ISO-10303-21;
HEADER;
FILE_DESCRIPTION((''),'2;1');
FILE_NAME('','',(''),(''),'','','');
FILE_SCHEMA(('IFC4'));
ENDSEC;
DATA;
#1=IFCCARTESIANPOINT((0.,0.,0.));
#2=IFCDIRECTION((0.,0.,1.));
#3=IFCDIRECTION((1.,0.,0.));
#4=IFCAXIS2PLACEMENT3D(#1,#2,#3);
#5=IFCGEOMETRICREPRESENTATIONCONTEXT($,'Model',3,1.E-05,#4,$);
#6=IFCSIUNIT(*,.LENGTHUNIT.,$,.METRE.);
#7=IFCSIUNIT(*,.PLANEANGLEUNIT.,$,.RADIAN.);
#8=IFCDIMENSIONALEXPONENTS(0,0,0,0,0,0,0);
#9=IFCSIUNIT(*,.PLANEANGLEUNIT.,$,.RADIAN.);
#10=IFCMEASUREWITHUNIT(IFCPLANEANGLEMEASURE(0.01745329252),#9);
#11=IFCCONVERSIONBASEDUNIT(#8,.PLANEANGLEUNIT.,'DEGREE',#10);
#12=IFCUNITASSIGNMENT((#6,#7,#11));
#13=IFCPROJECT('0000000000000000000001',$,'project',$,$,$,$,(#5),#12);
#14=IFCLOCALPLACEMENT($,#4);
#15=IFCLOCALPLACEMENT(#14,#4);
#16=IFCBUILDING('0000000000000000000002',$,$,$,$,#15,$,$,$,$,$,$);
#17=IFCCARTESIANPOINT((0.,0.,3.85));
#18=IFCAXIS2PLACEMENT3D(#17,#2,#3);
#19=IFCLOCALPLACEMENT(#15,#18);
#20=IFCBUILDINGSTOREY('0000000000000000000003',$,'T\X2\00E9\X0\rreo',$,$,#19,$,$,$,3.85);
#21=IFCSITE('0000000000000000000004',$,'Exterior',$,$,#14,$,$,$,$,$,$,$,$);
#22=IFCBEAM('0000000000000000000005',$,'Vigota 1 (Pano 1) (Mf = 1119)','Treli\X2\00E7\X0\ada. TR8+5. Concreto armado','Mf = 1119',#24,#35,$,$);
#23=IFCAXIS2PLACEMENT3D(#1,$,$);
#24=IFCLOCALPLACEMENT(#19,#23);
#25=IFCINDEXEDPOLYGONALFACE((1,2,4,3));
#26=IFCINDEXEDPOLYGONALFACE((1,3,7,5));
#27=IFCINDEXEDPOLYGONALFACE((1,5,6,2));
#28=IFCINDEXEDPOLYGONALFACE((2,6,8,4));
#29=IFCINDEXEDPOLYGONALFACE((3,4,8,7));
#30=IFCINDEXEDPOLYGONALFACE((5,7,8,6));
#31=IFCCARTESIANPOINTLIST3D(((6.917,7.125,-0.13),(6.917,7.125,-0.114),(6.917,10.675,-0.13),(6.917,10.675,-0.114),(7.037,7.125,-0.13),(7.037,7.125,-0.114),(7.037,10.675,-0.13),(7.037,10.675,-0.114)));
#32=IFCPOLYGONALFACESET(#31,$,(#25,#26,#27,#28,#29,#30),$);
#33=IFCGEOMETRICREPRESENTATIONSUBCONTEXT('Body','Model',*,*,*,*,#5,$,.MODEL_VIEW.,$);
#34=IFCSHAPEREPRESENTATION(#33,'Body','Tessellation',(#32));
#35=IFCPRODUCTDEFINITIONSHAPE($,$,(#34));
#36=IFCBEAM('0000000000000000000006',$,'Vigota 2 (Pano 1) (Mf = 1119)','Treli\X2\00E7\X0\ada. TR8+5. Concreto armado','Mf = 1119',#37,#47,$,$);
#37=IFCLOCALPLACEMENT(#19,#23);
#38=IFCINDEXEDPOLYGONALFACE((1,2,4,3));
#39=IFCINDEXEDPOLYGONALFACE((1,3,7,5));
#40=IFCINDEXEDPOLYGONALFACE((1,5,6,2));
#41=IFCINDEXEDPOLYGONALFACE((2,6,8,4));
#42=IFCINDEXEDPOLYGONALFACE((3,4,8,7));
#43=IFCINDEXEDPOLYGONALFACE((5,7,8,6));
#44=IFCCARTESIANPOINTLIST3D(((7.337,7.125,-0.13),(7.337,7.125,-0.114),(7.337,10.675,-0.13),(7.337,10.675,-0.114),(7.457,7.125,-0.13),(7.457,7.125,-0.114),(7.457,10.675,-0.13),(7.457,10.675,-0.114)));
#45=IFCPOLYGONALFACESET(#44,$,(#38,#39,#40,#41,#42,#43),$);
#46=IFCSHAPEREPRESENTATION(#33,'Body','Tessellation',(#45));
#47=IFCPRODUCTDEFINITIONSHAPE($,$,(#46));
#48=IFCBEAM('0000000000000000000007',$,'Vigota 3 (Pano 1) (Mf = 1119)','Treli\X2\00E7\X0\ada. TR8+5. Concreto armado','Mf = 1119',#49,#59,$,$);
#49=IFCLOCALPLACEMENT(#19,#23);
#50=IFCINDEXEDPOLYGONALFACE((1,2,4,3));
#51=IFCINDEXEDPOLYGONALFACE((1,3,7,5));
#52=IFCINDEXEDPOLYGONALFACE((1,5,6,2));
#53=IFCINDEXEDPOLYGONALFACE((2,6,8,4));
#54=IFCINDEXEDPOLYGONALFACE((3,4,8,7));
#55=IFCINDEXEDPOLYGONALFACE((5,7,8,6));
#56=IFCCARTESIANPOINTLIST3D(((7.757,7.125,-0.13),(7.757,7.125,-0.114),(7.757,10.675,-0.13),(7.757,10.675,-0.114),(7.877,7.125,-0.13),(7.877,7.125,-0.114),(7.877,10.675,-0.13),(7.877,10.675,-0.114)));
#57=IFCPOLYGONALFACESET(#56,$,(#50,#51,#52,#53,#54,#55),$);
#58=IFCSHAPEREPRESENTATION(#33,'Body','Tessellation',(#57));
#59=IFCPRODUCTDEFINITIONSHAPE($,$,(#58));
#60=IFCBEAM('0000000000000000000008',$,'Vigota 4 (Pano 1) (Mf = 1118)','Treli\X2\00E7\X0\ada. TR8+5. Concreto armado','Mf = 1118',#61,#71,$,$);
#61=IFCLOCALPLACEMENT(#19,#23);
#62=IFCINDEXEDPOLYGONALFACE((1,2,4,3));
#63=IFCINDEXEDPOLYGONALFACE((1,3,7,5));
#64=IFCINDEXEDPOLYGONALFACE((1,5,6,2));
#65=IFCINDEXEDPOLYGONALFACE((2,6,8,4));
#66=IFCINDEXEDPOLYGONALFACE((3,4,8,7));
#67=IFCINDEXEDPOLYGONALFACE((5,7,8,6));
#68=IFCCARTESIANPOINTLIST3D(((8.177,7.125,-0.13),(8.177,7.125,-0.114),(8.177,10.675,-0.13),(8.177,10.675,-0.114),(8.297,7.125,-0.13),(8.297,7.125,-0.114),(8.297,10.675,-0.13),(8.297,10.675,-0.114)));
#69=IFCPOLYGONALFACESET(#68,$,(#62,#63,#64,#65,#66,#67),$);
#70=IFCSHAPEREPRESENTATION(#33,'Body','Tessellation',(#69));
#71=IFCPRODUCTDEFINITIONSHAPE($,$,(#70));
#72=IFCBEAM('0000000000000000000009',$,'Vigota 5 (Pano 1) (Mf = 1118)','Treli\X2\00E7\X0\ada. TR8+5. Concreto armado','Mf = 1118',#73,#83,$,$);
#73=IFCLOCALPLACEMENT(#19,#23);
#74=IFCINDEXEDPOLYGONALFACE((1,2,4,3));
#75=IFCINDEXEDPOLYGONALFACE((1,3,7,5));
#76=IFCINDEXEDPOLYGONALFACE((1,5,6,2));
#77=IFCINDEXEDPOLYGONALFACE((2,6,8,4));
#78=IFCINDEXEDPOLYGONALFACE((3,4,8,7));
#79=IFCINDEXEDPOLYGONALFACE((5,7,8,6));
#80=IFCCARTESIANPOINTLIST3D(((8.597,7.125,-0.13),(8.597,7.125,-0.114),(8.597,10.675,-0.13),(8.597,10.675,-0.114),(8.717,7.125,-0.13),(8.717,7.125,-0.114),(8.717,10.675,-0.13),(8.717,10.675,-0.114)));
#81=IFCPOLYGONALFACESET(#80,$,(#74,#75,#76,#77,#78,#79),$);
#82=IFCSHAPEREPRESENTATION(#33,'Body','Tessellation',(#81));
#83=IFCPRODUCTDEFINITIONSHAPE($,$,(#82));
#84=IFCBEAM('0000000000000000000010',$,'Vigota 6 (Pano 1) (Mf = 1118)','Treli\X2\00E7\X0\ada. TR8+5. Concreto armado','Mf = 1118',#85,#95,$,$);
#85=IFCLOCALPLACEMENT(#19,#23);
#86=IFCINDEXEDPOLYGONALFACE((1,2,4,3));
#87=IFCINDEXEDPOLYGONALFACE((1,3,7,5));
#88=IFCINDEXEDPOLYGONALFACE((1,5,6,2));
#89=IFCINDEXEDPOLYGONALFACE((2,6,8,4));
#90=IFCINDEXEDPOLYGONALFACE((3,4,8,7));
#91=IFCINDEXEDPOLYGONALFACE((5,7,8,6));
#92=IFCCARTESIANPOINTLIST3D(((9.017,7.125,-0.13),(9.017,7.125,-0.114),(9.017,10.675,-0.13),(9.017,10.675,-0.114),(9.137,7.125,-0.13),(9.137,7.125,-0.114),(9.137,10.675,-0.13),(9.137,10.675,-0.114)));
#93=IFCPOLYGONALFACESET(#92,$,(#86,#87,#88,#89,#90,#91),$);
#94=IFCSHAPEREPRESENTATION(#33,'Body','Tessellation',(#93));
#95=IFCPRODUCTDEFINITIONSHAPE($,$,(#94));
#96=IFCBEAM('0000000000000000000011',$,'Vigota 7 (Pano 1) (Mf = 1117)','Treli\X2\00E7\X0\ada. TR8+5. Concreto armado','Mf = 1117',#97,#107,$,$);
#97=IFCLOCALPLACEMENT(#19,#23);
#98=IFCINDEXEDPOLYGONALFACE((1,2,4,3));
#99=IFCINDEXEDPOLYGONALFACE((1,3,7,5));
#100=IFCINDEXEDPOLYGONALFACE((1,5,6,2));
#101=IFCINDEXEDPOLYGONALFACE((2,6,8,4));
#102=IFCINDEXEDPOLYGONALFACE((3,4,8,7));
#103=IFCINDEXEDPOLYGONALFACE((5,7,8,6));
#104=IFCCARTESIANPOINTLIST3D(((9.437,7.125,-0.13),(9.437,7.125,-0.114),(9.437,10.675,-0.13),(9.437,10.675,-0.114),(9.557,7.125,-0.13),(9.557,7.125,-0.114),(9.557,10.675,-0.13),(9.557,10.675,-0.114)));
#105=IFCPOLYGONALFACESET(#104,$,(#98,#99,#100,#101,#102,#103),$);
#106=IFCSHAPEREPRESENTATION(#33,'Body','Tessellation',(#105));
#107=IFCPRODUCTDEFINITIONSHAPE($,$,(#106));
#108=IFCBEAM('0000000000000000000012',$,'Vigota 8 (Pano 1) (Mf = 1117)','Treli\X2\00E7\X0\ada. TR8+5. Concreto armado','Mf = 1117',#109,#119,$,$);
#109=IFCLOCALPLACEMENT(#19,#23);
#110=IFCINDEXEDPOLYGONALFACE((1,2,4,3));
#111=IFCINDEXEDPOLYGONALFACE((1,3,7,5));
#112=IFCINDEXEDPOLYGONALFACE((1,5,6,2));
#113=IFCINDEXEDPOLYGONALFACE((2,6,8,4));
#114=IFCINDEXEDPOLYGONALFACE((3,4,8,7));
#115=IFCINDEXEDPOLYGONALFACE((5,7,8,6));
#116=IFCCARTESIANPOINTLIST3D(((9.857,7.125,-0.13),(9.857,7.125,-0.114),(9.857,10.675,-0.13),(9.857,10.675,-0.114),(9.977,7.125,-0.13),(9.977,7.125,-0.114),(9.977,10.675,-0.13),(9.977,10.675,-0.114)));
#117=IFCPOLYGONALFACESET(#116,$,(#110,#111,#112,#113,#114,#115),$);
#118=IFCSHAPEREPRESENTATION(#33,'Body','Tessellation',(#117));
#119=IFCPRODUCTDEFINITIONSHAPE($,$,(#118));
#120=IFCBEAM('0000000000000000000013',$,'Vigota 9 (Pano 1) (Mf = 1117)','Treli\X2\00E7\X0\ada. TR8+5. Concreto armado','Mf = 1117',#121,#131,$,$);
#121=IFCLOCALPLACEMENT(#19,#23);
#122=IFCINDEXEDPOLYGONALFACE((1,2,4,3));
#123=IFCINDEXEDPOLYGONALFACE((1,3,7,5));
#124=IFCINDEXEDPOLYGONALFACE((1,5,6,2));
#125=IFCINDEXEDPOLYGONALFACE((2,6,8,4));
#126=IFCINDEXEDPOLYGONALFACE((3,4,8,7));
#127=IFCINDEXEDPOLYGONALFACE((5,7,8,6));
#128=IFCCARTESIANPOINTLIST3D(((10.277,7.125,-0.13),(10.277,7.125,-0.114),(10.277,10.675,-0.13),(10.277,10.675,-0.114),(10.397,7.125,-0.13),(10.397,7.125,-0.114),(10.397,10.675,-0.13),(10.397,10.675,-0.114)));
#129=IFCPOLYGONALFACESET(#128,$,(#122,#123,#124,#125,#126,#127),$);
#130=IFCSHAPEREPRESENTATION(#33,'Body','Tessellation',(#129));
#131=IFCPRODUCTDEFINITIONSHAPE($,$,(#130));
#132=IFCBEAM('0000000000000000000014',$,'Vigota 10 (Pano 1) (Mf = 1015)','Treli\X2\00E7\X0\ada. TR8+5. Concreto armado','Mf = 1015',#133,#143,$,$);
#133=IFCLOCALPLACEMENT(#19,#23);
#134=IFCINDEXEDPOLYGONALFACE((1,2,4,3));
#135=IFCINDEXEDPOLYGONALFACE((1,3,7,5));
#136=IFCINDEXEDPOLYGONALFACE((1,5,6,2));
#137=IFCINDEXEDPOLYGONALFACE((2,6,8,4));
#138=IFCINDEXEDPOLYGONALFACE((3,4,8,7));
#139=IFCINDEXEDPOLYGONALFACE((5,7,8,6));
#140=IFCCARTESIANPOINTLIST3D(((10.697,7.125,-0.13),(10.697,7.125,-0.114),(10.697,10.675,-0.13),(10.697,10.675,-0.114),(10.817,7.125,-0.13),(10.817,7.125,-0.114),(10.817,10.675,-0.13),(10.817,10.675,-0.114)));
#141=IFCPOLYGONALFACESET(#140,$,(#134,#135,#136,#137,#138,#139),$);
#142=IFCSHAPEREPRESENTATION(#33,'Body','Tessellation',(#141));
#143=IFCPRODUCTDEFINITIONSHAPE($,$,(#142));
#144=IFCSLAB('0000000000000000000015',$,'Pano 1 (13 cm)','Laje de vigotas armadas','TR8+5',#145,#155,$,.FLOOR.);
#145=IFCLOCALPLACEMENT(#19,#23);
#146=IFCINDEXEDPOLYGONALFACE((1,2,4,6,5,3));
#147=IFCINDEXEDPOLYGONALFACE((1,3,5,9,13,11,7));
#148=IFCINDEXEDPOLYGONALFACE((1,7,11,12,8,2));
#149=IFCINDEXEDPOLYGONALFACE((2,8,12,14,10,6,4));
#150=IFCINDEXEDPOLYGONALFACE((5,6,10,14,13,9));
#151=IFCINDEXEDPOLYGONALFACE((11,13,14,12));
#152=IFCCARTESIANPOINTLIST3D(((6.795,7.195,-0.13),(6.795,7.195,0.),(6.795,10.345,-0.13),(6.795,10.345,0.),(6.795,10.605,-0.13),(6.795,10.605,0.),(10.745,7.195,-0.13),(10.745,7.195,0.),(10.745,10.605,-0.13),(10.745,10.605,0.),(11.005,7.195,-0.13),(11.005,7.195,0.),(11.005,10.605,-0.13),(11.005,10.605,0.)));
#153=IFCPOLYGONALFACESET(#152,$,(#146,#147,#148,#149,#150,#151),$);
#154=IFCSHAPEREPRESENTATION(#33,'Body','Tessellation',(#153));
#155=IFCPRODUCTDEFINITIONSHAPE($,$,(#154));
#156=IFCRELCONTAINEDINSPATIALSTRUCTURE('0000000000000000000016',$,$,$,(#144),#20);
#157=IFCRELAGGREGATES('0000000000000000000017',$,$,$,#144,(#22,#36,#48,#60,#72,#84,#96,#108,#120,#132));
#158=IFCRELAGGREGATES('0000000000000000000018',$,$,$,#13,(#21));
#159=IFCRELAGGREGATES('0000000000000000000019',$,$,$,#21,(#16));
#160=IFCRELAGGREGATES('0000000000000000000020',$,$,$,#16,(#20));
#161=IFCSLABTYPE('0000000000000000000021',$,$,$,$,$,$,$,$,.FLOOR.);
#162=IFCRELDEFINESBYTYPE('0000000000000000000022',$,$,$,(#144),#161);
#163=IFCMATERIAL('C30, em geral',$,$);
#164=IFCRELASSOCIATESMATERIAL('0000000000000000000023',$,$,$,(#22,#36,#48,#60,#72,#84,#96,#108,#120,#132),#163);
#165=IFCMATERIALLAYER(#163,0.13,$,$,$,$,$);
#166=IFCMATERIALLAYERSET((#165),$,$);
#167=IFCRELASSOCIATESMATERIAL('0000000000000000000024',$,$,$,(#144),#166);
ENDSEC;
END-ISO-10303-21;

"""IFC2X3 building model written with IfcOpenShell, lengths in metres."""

from ifc_helpers import new_model, entity, si_unit, converted_unit, frame, origin_with_axes, place, context, subcontext, project, spatial, polyline, outline, extrude, material, layer, layer_set, layer_usage, type_object, element, aggregate, save


model = new_model("IFC2X3")

# Units and contexts
model_context = context("Model", 3, precision=1e-05, world=origin_with_axes())
body_context = subcontext(model_context, "Body", "Model", "MODEL_VIEW")
ifc_project = project(units=[si_unit("LENGTHUNIT", "METRE"), si_unit("PLANEANGLEUNIT", "RADIAN"), converted_unit("PLANEANGLEUNIT", "DEGREE", entity("IfcPlaneAngleMeasure", 0.01745329252), si_unit("PLANEANGLEUNIT", "RADIAN"), dimensions=[0, 0, 0, 0, 0, 0, 0])], contexts=[model_context])

# Beams
ifc_material = material(Name="C30, em geral")
site_placement = place(None, origin_with_axes())
building_placement = place(site_placement, origin_with_axes())
storey_placement = place(building_placement, frame((0.0, 0.0, 3.85), z_axis=(0.0, 0.0, 1.0), x_axis=(1.0, 0.0, 0.0)))
beam_1_placement = place(storey_placement, frame((6.977, 7.125, -0.122), z_axis=(0.0, 1.0, 0.0), x_axis=(-1.0, 0.0, 0.0)))
beam_1 = element("IfcBeam", 1, at=beam_1_placement, material=ifc_material, Name="Vigota 1 (Pano 1) (Mf = 1119)", Description="Treliçada. TR8+5. Concreto armado", ObjectType="Mf = 1119", context=body_context, shape_type="SweptSolid", body=[
    extrude(outline(polyline([(0.06, 0.008), (-0.06, 0.008), (-0.06, -0.008), (0.06, -0.008), (0.06, 0.008)])), origin_with_axes(), (0.0, 0.0, 1.0), 3.55),
])
beam_2_placement = place(storey_placement, frame((7.397, 7.125, -0.122), z_axis=(0.0, 1.0, 0.0), x_axis=(-1.0, 0.0, 0.0)))
beam_2 = element("IfcBeam", 2, at=beam_2_placement, material=ifc_material, Name="Vigota 2 (Pano 1) (Mf = 1119)", Description="Treliçada. TR8+5. Concreto armado", ObjectType="Mf = 1119", context=body_context, shape_type="SweptSolid", body=[
    extrude(outline(polyline([(0.06, 0.008), (-0.06, 0.008), (-0.06, -0.008), (0.06, -0.008), (0.06, 0.008)])), origin_with_axes(), (0.0, 0.0, 1.0), 3.55),
])
beam_3_placement = place(storey_placement, frame((7.817, 7.125, -0.122), z_axis=(0.0, 1.0, 0.0), x_axis=(-1.0, 0.0, 0.0)))
beam_3 = element("IfcBeam", 3, at=beam_3_placement, material=ifc_material, Name="Vigota 3 (Pano 1) (Mf = 1119)", Description="Treliçada. TR8+5. Concreto armado", ObjectType="Mf = 1119", context=body_context, shape_type="SweptSolid", body=[
    extrude(outline(polyline([(0.06, 0.008), (-0.06, 0.008), (-0.06, -0.008), (0.06, -0.008), (0.06, 0.008)])), origin_with_axes(), (0.0, 0.0, 1.0), 3.55),
])
beam_4_placement = place(storey_placement, frame((8.237, 7.125, -0.122), z_axis=(0.0, 1.0, 0.0), x_axis=(-1.0, 0.0, 0.0)))
beam_4 = element("IfcBeam", 4, at=beam_4_placement, material=ifc_material, Name="Vigota 4 (Pano 1) (Mf = 1118)", Description="Treliçada. TR8+5. Concreto armado", ObjectType="Mf = 1118", context=body_context, shape_type="SweptSolid", body=[
    extrude(outline(polyline([(0.06, 0.008), (-0.06, 0.008), (-0.06, -0.008), (0.06, -0.008), (0.06, 0.008)])), origin_with_axes(), (0.0, 0.0, 1.0), 3.55),
])
beam_5_placement = place(storey_placement, frame((8.657, 7.125, -0.122), z_axis=(0.0, 1.0, 0.0), x_axis=(-1.0, 0.0, 0.0)))
beam_5 = element("IfcBeam", 5, at=beam_5_placement, material=ifc_material, Name="Vigota 5 (Pano 1) (Mf = 1118)", Description="Treliçada. TR8+5. Concreto armado", ObjectType="Mf = 1118", context=body_context, shape_type="SweptSolid", body=[
    extrude(outline(polyline([(0.06, 0.008), (-0.06, 0.008), (-0.06, -0.008), (0.06, -0.008), (0.06, 0.008)])), origin_with_axes(), (0.0, 0.0, 1.0), 3.55),
])
beam_6_placement = place(storey_placement, frame((9.077, 7.125, -0.122), z_axis=(0.0, 1.0, 0.0), x_axis=(-1.0, 0.0, 0.0)))
beam_6 = element("IfcBeam", 6, at=beam_6_placement, material=ifc_material, Name="Vigota 6 (Pano 1) (Mf = 1118)", Description="Treliçada. TR8+5. Concreto armado", ObjectType="Mf = 1118", context=body_context, shape_type="SweptSolid", body=[
    extrude(outline(polyline([(0.06, 0.008), (-0.06, 0.008), (-0.06, -0.008), (0.06, -0.008), (0.06, 0.008)])), origin_with_axes(), (0.0, 0.0, 1.0), 3.55),
])
beam_7_placement = place(storey_placement, frame((9.497, 7.125, -0.122), z_axis=(0.0, 1.0, 0.0), x_axis=(-1.0, 0.0, 0.0)))
beam_7 = element("IfcBeam", 7, at=beam_7_placement, material=ifc_material, Name="Vigota 7 (Pano 1) (Mf = 1117)", Description="Treliçada. TR8+5. Concreto armado", ObjectType="Mf = 1117", context=body_context, shape_type="SweptSolid", body=[
    extrude(outline(polyline([(0.06, 0.008), (-0.06, 0.008), (-0.06, -0.008), (0.06, -0.008), (0.06, 0.008)])), origin_with_axes(), (0.0, 0.0, 1.0), 3.55),
])
beam_8_placement = place(storey_placement, frame((9.917, 7.125, -0.122), z_axis=(0.0, 1.0, 0.0), x_axis=(-1.0, 0.0, 0.0)))
beam_8 = element("IfcBeam", 8, at=beam_8_placement, material=ifc_material, Name="Vigota 8 (Pano 1) (Mf = 1117)", Description="Treliçada. TR8+5. Concreto armado", ObjectType="Mf = 1117", context=body_context, shape_type="SweptSolid", body=[
    extrude(outline(polyline([(0.06, 0.008), (-0.06, 0.008), (-0.06, -0.008), (0.06, -0.008), (0.06, 0.008)])), origin_with_axes(), (0.0, 0.0, 1.0), 3.55),
])
beam_9_placement = place(storey_placement, frame((10.337, 7.125, -0.122), z_axis=(0.0, 1.0, 0.0), x_axis=(-1.0, 0.0, 0.0)))
beam_9 = element("IfcBeam", 9, at=beam_9_placement, material=ifc_material, Name="Vigota 9 (Pano 1) (Mf = 1117)", Description="Treliçada. TR8+5. Concreto armado", ObjectType="Mf = 1117", context=body_context, shape_type="SweptSolid", body=[
    extrude(outline(polyline([(0.06, 0.008), (-0.06, 0.008), (-0.06, -0.008), (0.06, -0.008), (0.06, 0.008)])), origin_with_axes(), (0.0, 0.0, 1.0), 3.55),
])
beam_10_placement = place(storey_placement, frame((10.757, 7.125, -0.122), z_axis=(0.0, 1.0, 0.0), x_axis=(-1.0, 0.0, 0.0)))
beam_10 = element("IfcBeam", 10, at=beam_10_placement, material=ifc_material, Name="Vigota 10 (Pano 1) (Mf = 1015)", Description="Treliçada. TR8+5. Concreto armado", ObjectType="Mf = 1015", context=body_context, shape_type="SweptSolid", body=[
    extrude(outline(polyline([(0.06, 0.008), (-0.06, 0.008), (-0.06, -0.008), (0.06, -0.008), (0.06, 0.008)])), origin_with_axes(), (0.0, 0.0, 1.0), 3.55),
])

# Site, building, storey
site = spatial("IfcSite", under=ifc_project, at=site_placement, Name="Exterior")
building = spatial("IfcBuilding", under=site, at=building_placement)
storey = spatial("IfcBuildingStorey", under=building, at=storey_placement, Name="Térreo", Elevation=3.85)

# Slab
ifc_layer_1 = layer(ifc_material, 0.13)
ifc_layer_set_1 = layer_set([ifc_layer_1])
ifc_layer_usage_1 = layer_usage(ifc_layer_set_1, "AXIS3", "POSITIVE", 0.0)
slab_type = type_object("IfcSlabType", PredefinedType="FLOOR")
slab_1_placement = place(storey_placement, frame((0.0, 0.0, -0.13), z_axis=(0.0, 0.0, 1.0), x_axis=(1.0, 0.0, 0.0)))
slab_1 = element("IfcSlab", 11, at=slab_1_placement, inside=storey, type_object=slab_type, material=ifc_layer_usage_1, Name="Pano 1 (13 cm)", Description="Laje de vigotas armadas", ObjectType="TR8+5", PredefinedType="FLOOR", context=body_context, shape_type="SweptSolid", body=[
    extrude(outline(polyline([(11.005, 7.195), (11.005, 10.605), (10.745, 10.605), (6.795, 10.605), (6.795, 10.345), (6.795, 7.195), (10.745, 7.195), (11.005, 7.195)])), origin_with_axes(), (0.0, 0.0, 1.0), 0.13),
])
aggregate(slab_1, [beam_1, beam_2, beam_3, beam_4, beam_5, beam_6, beam_7, beam_8, beam_9, beam_10])

save(model, "model.ifc")
